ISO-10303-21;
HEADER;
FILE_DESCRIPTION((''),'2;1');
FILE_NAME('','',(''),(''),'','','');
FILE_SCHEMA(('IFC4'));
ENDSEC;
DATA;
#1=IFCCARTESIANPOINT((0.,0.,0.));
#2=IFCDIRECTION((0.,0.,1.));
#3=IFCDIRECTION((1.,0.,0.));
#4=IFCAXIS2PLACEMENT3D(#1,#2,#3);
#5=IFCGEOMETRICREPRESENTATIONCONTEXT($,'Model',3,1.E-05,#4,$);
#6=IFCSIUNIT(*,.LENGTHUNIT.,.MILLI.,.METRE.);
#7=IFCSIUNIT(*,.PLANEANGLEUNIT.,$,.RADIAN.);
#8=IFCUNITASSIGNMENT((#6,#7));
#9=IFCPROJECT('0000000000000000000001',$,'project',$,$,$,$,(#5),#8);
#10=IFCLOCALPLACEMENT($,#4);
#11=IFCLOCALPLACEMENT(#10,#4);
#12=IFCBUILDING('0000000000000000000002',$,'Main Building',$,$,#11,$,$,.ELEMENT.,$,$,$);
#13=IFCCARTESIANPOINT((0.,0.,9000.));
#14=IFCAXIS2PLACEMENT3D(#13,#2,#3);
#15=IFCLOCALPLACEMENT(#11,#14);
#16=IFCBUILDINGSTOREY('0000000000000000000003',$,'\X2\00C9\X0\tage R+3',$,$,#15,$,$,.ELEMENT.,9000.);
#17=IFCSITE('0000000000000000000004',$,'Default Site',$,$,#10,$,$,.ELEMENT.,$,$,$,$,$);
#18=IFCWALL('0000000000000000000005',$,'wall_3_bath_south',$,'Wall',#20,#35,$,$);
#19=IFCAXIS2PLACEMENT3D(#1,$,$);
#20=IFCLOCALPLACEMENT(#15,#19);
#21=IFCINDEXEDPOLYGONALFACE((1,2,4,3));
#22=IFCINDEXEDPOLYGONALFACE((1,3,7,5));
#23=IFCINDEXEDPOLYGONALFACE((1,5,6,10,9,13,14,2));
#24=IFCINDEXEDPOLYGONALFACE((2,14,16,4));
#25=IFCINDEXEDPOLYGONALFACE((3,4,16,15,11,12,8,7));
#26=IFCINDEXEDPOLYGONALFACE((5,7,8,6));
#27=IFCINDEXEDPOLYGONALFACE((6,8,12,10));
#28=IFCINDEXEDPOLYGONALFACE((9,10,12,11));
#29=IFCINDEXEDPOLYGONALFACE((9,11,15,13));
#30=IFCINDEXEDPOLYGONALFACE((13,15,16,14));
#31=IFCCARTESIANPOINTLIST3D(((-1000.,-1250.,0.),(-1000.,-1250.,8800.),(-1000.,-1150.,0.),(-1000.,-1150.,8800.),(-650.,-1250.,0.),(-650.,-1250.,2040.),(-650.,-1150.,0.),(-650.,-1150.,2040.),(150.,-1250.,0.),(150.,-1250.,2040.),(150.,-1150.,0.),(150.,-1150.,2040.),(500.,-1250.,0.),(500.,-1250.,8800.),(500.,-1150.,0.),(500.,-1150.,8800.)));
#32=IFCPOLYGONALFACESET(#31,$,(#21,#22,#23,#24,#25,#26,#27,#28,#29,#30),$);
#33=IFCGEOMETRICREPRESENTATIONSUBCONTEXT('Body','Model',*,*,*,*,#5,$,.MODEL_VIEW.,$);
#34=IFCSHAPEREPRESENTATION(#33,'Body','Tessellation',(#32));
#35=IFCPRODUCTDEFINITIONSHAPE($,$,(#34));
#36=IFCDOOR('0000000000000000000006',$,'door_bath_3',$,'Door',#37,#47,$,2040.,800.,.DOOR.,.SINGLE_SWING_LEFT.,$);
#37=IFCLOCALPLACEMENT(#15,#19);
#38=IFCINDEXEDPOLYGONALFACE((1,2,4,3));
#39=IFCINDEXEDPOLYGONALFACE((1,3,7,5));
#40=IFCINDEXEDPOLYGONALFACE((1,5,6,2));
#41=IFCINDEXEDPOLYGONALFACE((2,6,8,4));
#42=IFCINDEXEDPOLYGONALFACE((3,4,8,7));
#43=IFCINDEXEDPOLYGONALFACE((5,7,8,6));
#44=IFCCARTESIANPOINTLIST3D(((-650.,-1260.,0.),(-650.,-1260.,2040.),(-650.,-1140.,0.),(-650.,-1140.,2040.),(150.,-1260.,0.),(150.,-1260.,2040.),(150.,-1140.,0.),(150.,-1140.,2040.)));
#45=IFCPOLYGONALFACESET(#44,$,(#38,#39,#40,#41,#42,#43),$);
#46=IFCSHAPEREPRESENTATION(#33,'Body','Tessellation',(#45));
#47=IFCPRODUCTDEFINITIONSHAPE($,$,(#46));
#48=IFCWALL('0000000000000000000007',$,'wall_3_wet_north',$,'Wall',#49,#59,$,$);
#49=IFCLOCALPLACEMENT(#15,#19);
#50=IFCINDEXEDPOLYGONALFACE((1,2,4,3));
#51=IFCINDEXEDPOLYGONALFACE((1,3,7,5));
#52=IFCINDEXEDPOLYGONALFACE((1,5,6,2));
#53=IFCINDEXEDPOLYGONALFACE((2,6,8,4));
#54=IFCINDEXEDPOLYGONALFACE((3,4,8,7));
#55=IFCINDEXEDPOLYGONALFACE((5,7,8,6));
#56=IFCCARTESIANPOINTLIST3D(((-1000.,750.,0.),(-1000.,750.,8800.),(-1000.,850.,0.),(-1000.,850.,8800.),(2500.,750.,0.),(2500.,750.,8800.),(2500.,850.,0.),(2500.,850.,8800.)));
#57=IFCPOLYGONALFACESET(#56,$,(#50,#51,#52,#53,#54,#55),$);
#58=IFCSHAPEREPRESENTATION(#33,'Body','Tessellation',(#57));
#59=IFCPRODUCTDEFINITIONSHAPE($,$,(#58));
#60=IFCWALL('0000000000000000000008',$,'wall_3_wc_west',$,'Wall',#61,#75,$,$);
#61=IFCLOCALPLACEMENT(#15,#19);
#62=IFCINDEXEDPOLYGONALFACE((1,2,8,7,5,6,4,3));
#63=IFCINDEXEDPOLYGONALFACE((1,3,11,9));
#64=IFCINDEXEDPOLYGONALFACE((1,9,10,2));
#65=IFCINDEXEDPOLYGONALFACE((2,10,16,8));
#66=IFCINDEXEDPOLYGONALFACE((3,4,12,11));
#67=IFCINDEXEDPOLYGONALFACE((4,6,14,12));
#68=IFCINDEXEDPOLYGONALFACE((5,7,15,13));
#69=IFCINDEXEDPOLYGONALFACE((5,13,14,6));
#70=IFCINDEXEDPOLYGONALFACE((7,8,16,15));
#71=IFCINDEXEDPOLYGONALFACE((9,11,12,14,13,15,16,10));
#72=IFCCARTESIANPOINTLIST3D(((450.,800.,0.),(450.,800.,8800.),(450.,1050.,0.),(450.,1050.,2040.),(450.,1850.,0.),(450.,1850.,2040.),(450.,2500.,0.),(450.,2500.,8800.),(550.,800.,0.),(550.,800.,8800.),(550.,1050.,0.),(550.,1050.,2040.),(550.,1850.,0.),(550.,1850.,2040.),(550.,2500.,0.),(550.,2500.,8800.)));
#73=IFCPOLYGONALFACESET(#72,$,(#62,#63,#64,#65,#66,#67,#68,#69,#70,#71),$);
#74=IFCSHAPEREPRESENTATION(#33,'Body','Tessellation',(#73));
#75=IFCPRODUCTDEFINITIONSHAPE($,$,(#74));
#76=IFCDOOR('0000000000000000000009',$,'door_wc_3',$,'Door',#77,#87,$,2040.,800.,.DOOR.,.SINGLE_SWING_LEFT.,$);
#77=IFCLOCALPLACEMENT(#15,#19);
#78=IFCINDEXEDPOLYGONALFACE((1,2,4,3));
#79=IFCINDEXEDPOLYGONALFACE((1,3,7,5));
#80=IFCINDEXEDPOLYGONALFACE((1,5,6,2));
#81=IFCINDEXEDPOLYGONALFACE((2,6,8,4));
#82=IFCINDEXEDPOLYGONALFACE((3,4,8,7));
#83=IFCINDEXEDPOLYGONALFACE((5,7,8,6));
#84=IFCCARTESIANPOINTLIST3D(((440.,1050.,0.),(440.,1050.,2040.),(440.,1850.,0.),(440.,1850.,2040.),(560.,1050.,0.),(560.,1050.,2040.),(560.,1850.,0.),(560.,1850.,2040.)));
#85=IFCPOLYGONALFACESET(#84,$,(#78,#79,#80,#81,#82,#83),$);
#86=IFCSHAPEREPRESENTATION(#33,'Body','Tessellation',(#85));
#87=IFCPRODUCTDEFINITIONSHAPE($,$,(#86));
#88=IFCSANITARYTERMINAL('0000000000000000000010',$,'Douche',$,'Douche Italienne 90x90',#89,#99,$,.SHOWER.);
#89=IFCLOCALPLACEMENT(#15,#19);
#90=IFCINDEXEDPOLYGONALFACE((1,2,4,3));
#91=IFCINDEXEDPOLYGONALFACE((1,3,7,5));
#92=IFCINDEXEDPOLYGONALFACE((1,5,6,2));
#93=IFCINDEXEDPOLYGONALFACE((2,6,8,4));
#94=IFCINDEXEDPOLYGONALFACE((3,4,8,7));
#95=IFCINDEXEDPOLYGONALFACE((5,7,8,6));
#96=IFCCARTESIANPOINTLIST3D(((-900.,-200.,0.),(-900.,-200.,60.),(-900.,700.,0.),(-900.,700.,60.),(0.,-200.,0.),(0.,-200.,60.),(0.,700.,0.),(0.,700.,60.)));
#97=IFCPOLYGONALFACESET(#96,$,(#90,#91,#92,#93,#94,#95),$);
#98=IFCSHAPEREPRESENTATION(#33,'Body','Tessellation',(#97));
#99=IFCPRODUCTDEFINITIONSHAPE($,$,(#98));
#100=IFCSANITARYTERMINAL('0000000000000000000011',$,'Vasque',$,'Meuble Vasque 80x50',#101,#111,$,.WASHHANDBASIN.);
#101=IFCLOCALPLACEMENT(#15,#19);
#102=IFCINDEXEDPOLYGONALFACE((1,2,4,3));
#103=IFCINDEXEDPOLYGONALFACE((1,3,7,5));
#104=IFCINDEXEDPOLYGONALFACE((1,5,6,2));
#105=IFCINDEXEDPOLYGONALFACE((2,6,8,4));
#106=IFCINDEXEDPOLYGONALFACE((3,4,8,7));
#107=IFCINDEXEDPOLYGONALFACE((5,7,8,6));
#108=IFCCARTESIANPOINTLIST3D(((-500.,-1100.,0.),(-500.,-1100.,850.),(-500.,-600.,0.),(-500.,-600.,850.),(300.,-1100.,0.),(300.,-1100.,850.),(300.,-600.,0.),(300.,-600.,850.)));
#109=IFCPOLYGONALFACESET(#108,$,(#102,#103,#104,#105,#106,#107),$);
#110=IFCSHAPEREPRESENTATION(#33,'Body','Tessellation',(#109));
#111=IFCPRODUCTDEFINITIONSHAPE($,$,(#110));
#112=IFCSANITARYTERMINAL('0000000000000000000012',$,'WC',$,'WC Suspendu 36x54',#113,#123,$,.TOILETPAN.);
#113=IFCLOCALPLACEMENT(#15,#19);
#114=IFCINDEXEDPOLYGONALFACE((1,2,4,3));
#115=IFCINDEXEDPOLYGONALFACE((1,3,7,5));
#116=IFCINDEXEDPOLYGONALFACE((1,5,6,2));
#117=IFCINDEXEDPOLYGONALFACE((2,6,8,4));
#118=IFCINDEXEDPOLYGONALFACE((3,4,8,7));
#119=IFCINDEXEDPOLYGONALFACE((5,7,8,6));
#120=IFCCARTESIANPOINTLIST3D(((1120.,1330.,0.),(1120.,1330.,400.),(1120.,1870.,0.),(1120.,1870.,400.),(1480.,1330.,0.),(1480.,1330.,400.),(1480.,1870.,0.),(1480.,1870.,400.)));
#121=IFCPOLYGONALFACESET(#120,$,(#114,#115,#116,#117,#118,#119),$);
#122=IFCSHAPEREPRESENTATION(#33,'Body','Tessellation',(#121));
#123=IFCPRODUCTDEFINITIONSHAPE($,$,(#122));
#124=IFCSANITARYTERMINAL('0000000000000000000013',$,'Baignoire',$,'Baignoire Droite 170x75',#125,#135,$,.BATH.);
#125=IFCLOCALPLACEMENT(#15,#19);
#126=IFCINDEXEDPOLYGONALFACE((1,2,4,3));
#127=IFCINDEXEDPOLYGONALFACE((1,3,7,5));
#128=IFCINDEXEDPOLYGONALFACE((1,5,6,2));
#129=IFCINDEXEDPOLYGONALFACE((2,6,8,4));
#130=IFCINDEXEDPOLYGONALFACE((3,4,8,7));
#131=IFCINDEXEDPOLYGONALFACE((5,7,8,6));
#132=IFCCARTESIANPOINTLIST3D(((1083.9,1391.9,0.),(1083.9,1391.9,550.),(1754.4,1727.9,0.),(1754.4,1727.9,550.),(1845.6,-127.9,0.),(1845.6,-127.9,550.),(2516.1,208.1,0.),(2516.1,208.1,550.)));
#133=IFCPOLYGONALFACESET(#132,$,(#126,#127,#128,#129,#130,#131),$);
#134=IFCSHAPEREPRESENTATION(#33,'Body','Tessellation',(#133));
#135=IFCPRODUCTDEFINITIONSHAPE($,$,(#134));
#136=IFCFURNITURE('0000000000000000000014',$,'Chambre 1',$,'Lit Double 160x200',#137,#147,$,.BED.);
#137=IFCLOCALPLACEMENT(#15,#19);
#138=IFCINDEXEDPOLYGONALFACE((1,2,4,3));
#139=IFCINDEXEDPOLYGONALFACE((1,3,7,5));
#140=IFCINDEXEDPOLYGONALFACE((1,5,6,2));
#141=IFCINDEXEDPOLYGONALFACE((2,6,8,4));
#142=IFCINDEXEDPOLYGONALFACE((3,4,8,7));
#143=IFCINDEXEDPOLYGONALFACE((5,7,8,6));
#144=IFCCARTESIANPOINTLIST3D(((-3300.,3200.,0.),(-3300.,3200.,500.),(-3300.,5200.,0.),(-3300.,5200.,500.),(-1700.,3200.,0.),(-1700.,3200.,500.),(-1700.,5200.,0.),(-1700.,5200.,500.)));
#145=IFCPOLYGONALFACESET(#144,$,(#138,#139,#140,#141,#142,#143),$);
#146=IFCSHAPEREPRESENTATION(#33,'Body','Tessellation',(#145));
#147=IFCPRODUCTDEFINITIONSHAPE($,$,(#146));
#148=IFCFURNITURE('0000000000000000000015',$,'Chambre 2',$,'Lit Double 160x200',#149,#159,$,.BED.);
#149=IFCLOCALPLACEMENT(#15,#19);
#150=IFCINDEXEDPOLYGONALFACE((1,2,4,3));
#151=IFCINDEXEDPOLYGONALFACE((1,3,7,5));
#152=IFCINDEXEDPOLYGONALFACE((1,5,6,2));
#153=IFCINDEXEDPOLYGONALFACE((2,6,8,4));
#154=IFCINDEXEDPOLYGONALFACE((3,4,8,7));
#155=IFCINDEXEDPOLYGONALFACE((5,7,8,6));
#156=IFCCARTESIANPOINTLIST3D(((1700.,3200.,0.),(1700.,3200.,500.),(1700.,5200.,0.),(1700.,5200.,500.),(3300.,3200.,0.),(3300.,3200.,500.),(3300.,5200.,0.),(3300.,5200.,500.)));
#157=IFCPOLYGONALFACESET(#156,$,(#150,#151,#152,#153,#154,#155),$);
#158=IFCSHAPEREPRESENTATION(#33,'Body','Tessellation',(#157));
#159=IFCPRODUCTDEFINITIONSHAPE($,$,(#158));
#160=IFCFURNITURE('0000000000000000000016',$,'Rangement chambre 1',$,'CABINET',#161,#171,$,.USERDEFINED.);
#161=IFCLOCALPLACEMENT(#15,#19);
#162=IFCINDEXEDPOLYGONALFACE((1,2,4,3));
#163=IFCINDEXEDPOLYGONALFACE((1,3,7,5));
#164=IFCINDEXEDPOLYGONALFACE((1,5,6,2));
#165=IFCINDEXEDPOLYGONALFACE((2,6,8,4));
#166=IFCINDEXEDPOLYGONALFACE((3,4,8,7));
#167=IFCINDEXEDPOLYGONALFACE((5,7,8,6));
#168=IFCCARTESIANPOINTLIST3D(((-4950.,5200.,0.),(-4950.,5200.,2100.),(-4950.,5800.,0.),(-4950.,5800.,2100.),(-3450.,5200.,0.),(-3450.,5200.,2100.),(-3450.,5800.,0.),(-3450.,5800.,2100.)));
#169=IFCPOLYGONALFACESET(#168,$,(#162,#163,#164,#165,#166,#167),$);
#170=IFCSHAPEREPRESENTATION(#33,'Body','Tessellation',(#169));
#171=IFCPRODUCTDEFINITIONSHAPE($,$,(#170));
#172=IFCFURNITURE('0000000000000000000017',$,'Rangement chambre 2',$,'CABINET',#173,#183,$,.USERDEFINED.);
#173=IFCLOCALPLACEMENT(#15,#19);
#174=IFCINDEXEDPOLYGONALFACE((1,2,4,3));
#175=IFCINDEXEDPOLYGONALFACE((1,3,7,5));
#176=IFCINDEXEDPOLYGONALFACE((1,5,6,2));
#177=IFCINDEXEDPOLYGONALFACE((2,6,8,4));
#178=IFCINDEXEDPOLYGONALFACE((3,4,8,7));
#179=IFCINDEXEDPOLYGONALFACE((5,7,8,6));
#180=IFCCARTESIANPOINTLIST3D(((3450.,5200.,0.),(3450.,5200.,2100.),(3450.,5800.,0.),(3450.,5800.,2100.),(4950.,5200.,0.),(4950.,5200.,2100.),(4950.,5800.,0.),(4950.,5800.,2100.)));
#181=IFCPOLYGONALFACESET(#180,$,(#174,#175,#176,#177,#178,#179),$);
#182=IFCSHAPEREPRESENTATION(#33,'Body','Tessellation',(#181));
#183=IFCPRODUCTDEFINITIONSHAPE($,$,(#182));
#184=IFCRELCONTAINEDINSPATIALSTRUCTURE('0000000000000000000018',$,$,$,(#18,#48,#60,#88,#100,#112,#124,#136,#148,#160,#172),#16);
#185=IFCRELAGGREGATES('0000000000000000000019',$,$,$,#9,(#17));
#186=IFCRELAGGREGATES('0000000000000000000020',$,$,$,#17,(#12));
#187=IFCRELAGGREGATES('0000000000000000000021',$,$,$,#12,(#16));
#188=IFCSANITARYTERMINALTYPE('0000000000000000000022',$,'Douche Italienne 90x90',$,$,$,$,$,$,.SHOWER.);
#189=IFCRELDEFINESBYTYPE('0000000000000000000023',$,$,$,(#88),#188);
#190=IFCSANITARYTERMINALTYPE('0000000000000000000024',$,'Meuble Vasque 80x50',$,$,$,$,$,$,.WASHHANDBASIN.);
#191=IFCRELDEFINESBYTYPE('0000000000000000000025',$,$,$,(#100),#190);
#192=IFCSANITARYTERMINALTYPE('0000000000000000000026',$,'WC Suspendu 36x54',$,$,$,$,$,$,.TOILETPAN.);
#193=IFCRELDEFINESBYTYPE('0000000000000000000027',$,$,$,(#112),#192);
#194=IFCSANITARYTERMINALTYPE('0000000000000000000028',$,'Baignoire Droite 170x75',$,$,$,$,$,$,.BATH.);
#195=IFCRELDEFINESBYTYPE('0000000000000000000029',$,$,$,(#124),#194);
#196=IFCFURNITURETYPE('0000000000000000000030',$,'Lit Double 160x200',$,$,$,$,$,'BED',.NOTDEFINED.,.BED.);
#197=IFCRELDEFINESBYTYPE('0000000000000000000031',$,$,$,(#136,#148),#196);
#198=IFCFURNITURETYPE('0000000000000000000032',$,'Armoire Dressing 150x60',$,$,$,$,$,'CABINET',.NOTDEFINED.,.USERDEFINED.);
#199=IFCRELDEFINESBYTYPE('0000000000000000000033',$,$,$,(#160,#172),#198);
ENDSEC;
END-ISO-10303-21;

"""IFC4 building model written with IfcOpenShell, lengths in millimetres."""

from ifc_helpers import new_model, si_unit, frame, origin_with_axes, place, context, subcontext, project, spatial, polyline, outline, extrude, type_object, element, fill, save


model = new_model("IFC4")

# Units and contexts
model_context = context("Model", 3, precision=1e-05, world=origin_with_axes())
body_context = subcontext(model_context, "Body", "Model", "MODEL_VIEW")
ifc_project = project(units=[si_unit("LENGTHUNIT", "METRE", prefix="MILLI"), si_unit("PLANEANGLEUNIT", "RADIAN")], contexts=[model_context])

# Site, building, storey
site_placement = place(None, origin_with_axes())
site = spatial("IfcSite", under=ifc_project, at=site_placement, Name="Default Site", CompositionType="ELEMENT")
building_placement = place(site_placement, origin_with_axes())
building = spatial("IfcBuilding", under=site, at=building_placement, Name="Main Building", CompositionType="ELEMENT")
storey_placement = place(building_placement, frame((0.0, 0.0, 9000.0), z_axis=(0.0, 0.0, 1.0), x_axis=(1.0, 0.0, 0.0)))
storey = spatial("IfcBuildingStorey", under=building, at=storey_placement, Name="Étage R+3", CompositionType="ELEMENT", Elevation=9000.0)

# Wall, opening, door
wall_1_placement = place(storey_placement, frame((-1000.0, -1200.0, 0.0), z_axis=(0.0, 0.0, 1.0), x_axis=(1.0, 0.0, 0.0)))
wall_1 = element("IfcWall", 1, at=wall_1_placement, inside=storey, Name="wall_3_bath_south", ObjectType="Wall", context=body_context, shape_type="SweptSolid", body=[
    extrude(outline(polyline([(0.0, -50.0), (1500.0, -50.0), (1500.0, 50.0), (0.0, 50.0), (0.0, -50.0)])), origin_with_axes(), (0.0, 0.0, 1.0), 8800.0),
])
placement_1 = place(wall_1_placement, frame((350.0, 0.0, 0.0), z_axis=(0.0, 0.0, 1.0), x_axis=(1.0, 0.0, 0.0)))
opening_1 = element("IfcOpeningElement", 2, at=placement_1, cuts=wall_1, PredefinedType="OPENING", context=body_context, shape_type="SweptSolid", body=[
    extrude(outline(polyline([(0.0, -60.0), (800.0, -60.0), (800.0, 60.0), (0.0, 60.0), (0.0, -60.0)])), origin_with_axes(), (0.0, 0.0, 1.0), 2040.0),
])
door_1 = element("IfcDoor", 3, at=placement_1, Name="door_bath_3", ObjectType="Door", OperationType="SINGLE_SWING_LEFT", OverallHeight=2040.0, OverallWidth=800.0, PredefinedType="DOOR", context=body_context, shape_type="SweptSolid", body=[
    extrude(outline(polyline([(0.0, -60.0), (800.0, -60.0), (800.0, 60.0), (0.0, 60.0), (0.0, -60.0)])), origin_with_axes(), (0.0, 0.0, 1.0), 2040.0),
])
fill(opening_1, door_1)

# Wall
wall_2_placement = place(storey_placement, frame((-1000.0, 800.0, 0.0), z_axis=(0.0, 0.0, 1.0), x_axis=(1.0, 0.0, 0.0)))
element("IfcWall", 4, at=wall_2_placement, inside=storey, Name="wall_3_wet_north", ObjectType="Wall", context=body_context, shape_type="SweptSolid", body=[
    extrude(outline(polyline([(0.0, -50.0), (3500.0, -50.0), (3500.0, 50.0), (0.0, 50.0), (0.0, -50.0)])), origin_with_axes(), (0.0, 0.0, 1.0), 8800.0),
])

# Wall, opening, door
wall_3_placement = place(storey_placement, frame((500.0, 800.0, 0.0), z_axis=(0.0, 0.0, 1.0), x_axis=(0.0, 1.0, 0.0)))
wall_3 = element("IfcWall", 5, at=wall_3_placement, inside=storey, Name="wall_3_wc_west", ObjectType="Wall", context=body_context, shape_type="SweptSolid", body=[
    extrude(outline(polyline([(0.0, -50.0), (1700.0, -50.0), (1700.0, 50.0), (0.0, 50.0), (0.0, -50.0)])), origin_with_axes(), (0.0, 0.0, 1.0), 8800.0),
])
placement_2 = place(wall_3_placement, frame((250.0, 0.0, 0.0), z_axis=(0.0, 0.0, 1.0), x_axis=(1.0, 0.0, 0.0)))
opening_2 = element("IfcOpeningElement", 6, at=placement_2, cuts=wall_3, PredefinedType="OPENING", context=body_context, shape_type="SweptSolid", body=[
    extrude(outline(polyline([(0.0, -60.0), (800.0, -60.0), (800.0, 60.0), (0.0, 60.0), (0.0, -60.0)])), origin_with_axes(), (0.0, 0.0, 1.0), 2040.0),
])
door_2 = element("IfcDoor", 7, at=placement_2, Name="door_wc_3", ObjectType="Door", OperationType="SINGLE_SWING_LEFT", OverallHeight=2040.0, OverallWidth=800.0, PredefinedType="DOOR", context=body_context, shape_type="SweptSolid", body=[
    extrude(outline(polyline([(0.0, -60.0), (800.0, -60.0), (800.0, 60.0), (0.0, 60.0), (0.0, -60.0)])), origin_with_axes(), (0.0, 0.0, 1.0), 2040.0),
])
fill(opening_2, door_2)

# Sanitary terminals
sanitary_terminal_type_1 = type_object("IfcSanitaryTerminalType", Name="Douche Italienne 90x90", PredefinedType="SHOWER")
sanitary_terminal_1_placement = place(storey_placement, frame((-450.0, 250.0, 0.0), z_axis=(0.0, 0.0, 1.0), x_axis=(1.0, 0.0, 0.0)))
element("IfcSanitaryTerminal", 8, at=sanitary_terminal_1_placement, inside=storey, type_object=sanitary_terminal_type_1, Name="Douche", ObjectType="Douche Italienne 90x90", PredefinedType="SHOWER", context=body_context, shape_type="SweptSolid", body=[
    extrude(outline(polyline([(-450.0, -450.0), (450.0, -450.0), (450.0, 450.0), (-450.0, 450.0), (-450.0, -450.0)])), origin_with_axes(), (0.0, 0.0, 1.0), 60.0),
])
sanitary_terminal_type_2 = type_object("IfcSanitaryTerminalType", Name="Meuble Vasque 80x50", PredefinedType="WASHHANDBASIN")
sanitary_terminal_2_placement = place(storey_placement, frame((-100.0, -850.0, 0.0), z_axis=(0.0, 0.0, 1.0), x_axis=(1.0, 0.0, 0.0)))
element("IfcSanitaryTerminal", 9, at=sanitary_terminal_2_placement, inside=storey, type_object=sanitary_terminal_type_2, Name="Vasque", ObjectType="Meuble Vasque 80x50", PredefinedType="WASHHANDBASIN", context=body_context, shape_type="SweptSolid", body=[
    extrude(outline(polyline([(-400.0, -250.0), (400.0, -250.0), (400.0, 250.0), (-400.0, 250.0), (-400.0, -250.0)])), origin_with_axes(), (0.0, 0.0, 1.0), 850.0),
])
sanitary_terminal_type_3 = type_object("IfcSanitaryTerminalType", Name="WC Suspendu 36x54", PredefinedType="TOILETPAN")
sanitary_terminal_3_placement = place(storey_placement, frame((1300.0, 1600.0, 0.0), z_axis=(0.0, 0.0, 1.0), x_axis=(1.0, 0.0, 0.0)))
element("IfcSanitaryTerminal", 10, at=sanitary_terminal_3_placement, inside=storey, type_object=sanitary_terminal_type_3, Name="WC", ObjectType="WC Suspendu 36x54", PredefinedType="TOILETPAN", context=body_context, shape_type="SweptSolid", body=[
    extrude(outline(polyline([(-180.0, -270.0), (180.0, -270.0), (180.0, 270.0), (-180.0, 270.0), (-180.0, -270.0)])), origin_with_axes(), (0.0, 0.0, 1.0), 400.0),
])
sanitary_terminal_type_4 = type_object("IfcSanitaryTerminalType", Name="Baignoire Droite 170x75", PredefinedType="BATH")
sanitary_terminal_4_placement = place(storey_placement, frame((1800.0, 800.0, 0.0), z_axis=(0.0, 0.0, 1.0), x_axis=(-0.448074, 0.893997, 0.0)))
element("IfcSanitaryTerminal", 11, at=sanitary_terminal_4_placement, inside=storey, type_object=sanitary_terminal_type_4, Name="Baignoire", ObjectType="Baignoire Droite 170x75", PredefinedType="BATH", context=body_context, shape_type="SweptSolid", body=[
    extrude(outline(polyline([(-850.0, -375.0), (850.0, -375.0), (850.0, 375.0), (-850.0, 375.0), (-850.0, -375.0)])), origin_with_axes(), (0.0, 0.0, 1.0), 550.0),
])

# Furniture
furniture_type_1 = type_object("IfcFurnitureType", Name="Lit Double 160x200", ElementType="BED", AssemblyPlace="NOTDEFINED", PredefinedType="BED")
for number, where, z_axis, x_axis, name in (
    (12, (-2500.0, 4200.0, 0.0), (0.0, 0.0, 1.0), (1.0, 0.0, 0.0), "Chambre 1"),
    (13, (2500.0, 4200.0, 0.0), (0.0, 0.0, 1.0), (1.0, 0.0, 0.0), "Chambre 2"),
):
    element("IfcFurniture", number, at=place(storey_placement, frame(where, z_axis=z_axis, x_axis=x_axis)), inside=storey, type_object=furniture_type_1, Name=name, ObjectType="Lit Double 160x200", PredefinedType="BED", context=body_context, shape_type="SweptSolid", body=[
        extrude(outline(polyline([(-800.0, -1000.0), (800.0, -1000.0), (800.0, 1000.0), (-800.0, 1000.0), (-800.0, -1000.0)])), origin_with_axes(), (0.0, 0.0, 1.0), 500.0),
    ])
furniture_type_2 = type_object("IfcFurnitureType", Name="Armoire Dressing 150x60", ElementType="CABINET", AssemblyPlace="NOTDEFINED", PredefinedType="USERDEFINED")
for number, where, z_axis, x_axis, name in (
    (14, (-4200.0, 5500.0, 0.0), (0.0, 0.0, 1.0), (1.0, 0.0, 0.0), "Rangement chambre 1"),
    (15, (4200.0, 5500.0, 0.0), (0.0, 0.0, 1.0), (1.0, 0.0, 0.0), "Rangement chambre 2"),
):
    element("IfcFurniture", number, at=place(storey_placement, frame(where, z_axis=z_axis, x_axis=x_axis)), inside=storey, type_object=furniture_type_2, Name=name, ObjectType="CABINET", PredefinedType="USERDEFINED", context=body_context, shape_type="SweptSolid", body=[
        extrude(outline(polyline([(-750.0, -300.0), (750.0, -300.0), (750.0, 300.0), (-750.0, 300.0), (-750.0, -300.0)])), origin_with_axes(), (0.0, 0.0, 1.0), 2100.0),
    ])

save(model, "model.ifc")
